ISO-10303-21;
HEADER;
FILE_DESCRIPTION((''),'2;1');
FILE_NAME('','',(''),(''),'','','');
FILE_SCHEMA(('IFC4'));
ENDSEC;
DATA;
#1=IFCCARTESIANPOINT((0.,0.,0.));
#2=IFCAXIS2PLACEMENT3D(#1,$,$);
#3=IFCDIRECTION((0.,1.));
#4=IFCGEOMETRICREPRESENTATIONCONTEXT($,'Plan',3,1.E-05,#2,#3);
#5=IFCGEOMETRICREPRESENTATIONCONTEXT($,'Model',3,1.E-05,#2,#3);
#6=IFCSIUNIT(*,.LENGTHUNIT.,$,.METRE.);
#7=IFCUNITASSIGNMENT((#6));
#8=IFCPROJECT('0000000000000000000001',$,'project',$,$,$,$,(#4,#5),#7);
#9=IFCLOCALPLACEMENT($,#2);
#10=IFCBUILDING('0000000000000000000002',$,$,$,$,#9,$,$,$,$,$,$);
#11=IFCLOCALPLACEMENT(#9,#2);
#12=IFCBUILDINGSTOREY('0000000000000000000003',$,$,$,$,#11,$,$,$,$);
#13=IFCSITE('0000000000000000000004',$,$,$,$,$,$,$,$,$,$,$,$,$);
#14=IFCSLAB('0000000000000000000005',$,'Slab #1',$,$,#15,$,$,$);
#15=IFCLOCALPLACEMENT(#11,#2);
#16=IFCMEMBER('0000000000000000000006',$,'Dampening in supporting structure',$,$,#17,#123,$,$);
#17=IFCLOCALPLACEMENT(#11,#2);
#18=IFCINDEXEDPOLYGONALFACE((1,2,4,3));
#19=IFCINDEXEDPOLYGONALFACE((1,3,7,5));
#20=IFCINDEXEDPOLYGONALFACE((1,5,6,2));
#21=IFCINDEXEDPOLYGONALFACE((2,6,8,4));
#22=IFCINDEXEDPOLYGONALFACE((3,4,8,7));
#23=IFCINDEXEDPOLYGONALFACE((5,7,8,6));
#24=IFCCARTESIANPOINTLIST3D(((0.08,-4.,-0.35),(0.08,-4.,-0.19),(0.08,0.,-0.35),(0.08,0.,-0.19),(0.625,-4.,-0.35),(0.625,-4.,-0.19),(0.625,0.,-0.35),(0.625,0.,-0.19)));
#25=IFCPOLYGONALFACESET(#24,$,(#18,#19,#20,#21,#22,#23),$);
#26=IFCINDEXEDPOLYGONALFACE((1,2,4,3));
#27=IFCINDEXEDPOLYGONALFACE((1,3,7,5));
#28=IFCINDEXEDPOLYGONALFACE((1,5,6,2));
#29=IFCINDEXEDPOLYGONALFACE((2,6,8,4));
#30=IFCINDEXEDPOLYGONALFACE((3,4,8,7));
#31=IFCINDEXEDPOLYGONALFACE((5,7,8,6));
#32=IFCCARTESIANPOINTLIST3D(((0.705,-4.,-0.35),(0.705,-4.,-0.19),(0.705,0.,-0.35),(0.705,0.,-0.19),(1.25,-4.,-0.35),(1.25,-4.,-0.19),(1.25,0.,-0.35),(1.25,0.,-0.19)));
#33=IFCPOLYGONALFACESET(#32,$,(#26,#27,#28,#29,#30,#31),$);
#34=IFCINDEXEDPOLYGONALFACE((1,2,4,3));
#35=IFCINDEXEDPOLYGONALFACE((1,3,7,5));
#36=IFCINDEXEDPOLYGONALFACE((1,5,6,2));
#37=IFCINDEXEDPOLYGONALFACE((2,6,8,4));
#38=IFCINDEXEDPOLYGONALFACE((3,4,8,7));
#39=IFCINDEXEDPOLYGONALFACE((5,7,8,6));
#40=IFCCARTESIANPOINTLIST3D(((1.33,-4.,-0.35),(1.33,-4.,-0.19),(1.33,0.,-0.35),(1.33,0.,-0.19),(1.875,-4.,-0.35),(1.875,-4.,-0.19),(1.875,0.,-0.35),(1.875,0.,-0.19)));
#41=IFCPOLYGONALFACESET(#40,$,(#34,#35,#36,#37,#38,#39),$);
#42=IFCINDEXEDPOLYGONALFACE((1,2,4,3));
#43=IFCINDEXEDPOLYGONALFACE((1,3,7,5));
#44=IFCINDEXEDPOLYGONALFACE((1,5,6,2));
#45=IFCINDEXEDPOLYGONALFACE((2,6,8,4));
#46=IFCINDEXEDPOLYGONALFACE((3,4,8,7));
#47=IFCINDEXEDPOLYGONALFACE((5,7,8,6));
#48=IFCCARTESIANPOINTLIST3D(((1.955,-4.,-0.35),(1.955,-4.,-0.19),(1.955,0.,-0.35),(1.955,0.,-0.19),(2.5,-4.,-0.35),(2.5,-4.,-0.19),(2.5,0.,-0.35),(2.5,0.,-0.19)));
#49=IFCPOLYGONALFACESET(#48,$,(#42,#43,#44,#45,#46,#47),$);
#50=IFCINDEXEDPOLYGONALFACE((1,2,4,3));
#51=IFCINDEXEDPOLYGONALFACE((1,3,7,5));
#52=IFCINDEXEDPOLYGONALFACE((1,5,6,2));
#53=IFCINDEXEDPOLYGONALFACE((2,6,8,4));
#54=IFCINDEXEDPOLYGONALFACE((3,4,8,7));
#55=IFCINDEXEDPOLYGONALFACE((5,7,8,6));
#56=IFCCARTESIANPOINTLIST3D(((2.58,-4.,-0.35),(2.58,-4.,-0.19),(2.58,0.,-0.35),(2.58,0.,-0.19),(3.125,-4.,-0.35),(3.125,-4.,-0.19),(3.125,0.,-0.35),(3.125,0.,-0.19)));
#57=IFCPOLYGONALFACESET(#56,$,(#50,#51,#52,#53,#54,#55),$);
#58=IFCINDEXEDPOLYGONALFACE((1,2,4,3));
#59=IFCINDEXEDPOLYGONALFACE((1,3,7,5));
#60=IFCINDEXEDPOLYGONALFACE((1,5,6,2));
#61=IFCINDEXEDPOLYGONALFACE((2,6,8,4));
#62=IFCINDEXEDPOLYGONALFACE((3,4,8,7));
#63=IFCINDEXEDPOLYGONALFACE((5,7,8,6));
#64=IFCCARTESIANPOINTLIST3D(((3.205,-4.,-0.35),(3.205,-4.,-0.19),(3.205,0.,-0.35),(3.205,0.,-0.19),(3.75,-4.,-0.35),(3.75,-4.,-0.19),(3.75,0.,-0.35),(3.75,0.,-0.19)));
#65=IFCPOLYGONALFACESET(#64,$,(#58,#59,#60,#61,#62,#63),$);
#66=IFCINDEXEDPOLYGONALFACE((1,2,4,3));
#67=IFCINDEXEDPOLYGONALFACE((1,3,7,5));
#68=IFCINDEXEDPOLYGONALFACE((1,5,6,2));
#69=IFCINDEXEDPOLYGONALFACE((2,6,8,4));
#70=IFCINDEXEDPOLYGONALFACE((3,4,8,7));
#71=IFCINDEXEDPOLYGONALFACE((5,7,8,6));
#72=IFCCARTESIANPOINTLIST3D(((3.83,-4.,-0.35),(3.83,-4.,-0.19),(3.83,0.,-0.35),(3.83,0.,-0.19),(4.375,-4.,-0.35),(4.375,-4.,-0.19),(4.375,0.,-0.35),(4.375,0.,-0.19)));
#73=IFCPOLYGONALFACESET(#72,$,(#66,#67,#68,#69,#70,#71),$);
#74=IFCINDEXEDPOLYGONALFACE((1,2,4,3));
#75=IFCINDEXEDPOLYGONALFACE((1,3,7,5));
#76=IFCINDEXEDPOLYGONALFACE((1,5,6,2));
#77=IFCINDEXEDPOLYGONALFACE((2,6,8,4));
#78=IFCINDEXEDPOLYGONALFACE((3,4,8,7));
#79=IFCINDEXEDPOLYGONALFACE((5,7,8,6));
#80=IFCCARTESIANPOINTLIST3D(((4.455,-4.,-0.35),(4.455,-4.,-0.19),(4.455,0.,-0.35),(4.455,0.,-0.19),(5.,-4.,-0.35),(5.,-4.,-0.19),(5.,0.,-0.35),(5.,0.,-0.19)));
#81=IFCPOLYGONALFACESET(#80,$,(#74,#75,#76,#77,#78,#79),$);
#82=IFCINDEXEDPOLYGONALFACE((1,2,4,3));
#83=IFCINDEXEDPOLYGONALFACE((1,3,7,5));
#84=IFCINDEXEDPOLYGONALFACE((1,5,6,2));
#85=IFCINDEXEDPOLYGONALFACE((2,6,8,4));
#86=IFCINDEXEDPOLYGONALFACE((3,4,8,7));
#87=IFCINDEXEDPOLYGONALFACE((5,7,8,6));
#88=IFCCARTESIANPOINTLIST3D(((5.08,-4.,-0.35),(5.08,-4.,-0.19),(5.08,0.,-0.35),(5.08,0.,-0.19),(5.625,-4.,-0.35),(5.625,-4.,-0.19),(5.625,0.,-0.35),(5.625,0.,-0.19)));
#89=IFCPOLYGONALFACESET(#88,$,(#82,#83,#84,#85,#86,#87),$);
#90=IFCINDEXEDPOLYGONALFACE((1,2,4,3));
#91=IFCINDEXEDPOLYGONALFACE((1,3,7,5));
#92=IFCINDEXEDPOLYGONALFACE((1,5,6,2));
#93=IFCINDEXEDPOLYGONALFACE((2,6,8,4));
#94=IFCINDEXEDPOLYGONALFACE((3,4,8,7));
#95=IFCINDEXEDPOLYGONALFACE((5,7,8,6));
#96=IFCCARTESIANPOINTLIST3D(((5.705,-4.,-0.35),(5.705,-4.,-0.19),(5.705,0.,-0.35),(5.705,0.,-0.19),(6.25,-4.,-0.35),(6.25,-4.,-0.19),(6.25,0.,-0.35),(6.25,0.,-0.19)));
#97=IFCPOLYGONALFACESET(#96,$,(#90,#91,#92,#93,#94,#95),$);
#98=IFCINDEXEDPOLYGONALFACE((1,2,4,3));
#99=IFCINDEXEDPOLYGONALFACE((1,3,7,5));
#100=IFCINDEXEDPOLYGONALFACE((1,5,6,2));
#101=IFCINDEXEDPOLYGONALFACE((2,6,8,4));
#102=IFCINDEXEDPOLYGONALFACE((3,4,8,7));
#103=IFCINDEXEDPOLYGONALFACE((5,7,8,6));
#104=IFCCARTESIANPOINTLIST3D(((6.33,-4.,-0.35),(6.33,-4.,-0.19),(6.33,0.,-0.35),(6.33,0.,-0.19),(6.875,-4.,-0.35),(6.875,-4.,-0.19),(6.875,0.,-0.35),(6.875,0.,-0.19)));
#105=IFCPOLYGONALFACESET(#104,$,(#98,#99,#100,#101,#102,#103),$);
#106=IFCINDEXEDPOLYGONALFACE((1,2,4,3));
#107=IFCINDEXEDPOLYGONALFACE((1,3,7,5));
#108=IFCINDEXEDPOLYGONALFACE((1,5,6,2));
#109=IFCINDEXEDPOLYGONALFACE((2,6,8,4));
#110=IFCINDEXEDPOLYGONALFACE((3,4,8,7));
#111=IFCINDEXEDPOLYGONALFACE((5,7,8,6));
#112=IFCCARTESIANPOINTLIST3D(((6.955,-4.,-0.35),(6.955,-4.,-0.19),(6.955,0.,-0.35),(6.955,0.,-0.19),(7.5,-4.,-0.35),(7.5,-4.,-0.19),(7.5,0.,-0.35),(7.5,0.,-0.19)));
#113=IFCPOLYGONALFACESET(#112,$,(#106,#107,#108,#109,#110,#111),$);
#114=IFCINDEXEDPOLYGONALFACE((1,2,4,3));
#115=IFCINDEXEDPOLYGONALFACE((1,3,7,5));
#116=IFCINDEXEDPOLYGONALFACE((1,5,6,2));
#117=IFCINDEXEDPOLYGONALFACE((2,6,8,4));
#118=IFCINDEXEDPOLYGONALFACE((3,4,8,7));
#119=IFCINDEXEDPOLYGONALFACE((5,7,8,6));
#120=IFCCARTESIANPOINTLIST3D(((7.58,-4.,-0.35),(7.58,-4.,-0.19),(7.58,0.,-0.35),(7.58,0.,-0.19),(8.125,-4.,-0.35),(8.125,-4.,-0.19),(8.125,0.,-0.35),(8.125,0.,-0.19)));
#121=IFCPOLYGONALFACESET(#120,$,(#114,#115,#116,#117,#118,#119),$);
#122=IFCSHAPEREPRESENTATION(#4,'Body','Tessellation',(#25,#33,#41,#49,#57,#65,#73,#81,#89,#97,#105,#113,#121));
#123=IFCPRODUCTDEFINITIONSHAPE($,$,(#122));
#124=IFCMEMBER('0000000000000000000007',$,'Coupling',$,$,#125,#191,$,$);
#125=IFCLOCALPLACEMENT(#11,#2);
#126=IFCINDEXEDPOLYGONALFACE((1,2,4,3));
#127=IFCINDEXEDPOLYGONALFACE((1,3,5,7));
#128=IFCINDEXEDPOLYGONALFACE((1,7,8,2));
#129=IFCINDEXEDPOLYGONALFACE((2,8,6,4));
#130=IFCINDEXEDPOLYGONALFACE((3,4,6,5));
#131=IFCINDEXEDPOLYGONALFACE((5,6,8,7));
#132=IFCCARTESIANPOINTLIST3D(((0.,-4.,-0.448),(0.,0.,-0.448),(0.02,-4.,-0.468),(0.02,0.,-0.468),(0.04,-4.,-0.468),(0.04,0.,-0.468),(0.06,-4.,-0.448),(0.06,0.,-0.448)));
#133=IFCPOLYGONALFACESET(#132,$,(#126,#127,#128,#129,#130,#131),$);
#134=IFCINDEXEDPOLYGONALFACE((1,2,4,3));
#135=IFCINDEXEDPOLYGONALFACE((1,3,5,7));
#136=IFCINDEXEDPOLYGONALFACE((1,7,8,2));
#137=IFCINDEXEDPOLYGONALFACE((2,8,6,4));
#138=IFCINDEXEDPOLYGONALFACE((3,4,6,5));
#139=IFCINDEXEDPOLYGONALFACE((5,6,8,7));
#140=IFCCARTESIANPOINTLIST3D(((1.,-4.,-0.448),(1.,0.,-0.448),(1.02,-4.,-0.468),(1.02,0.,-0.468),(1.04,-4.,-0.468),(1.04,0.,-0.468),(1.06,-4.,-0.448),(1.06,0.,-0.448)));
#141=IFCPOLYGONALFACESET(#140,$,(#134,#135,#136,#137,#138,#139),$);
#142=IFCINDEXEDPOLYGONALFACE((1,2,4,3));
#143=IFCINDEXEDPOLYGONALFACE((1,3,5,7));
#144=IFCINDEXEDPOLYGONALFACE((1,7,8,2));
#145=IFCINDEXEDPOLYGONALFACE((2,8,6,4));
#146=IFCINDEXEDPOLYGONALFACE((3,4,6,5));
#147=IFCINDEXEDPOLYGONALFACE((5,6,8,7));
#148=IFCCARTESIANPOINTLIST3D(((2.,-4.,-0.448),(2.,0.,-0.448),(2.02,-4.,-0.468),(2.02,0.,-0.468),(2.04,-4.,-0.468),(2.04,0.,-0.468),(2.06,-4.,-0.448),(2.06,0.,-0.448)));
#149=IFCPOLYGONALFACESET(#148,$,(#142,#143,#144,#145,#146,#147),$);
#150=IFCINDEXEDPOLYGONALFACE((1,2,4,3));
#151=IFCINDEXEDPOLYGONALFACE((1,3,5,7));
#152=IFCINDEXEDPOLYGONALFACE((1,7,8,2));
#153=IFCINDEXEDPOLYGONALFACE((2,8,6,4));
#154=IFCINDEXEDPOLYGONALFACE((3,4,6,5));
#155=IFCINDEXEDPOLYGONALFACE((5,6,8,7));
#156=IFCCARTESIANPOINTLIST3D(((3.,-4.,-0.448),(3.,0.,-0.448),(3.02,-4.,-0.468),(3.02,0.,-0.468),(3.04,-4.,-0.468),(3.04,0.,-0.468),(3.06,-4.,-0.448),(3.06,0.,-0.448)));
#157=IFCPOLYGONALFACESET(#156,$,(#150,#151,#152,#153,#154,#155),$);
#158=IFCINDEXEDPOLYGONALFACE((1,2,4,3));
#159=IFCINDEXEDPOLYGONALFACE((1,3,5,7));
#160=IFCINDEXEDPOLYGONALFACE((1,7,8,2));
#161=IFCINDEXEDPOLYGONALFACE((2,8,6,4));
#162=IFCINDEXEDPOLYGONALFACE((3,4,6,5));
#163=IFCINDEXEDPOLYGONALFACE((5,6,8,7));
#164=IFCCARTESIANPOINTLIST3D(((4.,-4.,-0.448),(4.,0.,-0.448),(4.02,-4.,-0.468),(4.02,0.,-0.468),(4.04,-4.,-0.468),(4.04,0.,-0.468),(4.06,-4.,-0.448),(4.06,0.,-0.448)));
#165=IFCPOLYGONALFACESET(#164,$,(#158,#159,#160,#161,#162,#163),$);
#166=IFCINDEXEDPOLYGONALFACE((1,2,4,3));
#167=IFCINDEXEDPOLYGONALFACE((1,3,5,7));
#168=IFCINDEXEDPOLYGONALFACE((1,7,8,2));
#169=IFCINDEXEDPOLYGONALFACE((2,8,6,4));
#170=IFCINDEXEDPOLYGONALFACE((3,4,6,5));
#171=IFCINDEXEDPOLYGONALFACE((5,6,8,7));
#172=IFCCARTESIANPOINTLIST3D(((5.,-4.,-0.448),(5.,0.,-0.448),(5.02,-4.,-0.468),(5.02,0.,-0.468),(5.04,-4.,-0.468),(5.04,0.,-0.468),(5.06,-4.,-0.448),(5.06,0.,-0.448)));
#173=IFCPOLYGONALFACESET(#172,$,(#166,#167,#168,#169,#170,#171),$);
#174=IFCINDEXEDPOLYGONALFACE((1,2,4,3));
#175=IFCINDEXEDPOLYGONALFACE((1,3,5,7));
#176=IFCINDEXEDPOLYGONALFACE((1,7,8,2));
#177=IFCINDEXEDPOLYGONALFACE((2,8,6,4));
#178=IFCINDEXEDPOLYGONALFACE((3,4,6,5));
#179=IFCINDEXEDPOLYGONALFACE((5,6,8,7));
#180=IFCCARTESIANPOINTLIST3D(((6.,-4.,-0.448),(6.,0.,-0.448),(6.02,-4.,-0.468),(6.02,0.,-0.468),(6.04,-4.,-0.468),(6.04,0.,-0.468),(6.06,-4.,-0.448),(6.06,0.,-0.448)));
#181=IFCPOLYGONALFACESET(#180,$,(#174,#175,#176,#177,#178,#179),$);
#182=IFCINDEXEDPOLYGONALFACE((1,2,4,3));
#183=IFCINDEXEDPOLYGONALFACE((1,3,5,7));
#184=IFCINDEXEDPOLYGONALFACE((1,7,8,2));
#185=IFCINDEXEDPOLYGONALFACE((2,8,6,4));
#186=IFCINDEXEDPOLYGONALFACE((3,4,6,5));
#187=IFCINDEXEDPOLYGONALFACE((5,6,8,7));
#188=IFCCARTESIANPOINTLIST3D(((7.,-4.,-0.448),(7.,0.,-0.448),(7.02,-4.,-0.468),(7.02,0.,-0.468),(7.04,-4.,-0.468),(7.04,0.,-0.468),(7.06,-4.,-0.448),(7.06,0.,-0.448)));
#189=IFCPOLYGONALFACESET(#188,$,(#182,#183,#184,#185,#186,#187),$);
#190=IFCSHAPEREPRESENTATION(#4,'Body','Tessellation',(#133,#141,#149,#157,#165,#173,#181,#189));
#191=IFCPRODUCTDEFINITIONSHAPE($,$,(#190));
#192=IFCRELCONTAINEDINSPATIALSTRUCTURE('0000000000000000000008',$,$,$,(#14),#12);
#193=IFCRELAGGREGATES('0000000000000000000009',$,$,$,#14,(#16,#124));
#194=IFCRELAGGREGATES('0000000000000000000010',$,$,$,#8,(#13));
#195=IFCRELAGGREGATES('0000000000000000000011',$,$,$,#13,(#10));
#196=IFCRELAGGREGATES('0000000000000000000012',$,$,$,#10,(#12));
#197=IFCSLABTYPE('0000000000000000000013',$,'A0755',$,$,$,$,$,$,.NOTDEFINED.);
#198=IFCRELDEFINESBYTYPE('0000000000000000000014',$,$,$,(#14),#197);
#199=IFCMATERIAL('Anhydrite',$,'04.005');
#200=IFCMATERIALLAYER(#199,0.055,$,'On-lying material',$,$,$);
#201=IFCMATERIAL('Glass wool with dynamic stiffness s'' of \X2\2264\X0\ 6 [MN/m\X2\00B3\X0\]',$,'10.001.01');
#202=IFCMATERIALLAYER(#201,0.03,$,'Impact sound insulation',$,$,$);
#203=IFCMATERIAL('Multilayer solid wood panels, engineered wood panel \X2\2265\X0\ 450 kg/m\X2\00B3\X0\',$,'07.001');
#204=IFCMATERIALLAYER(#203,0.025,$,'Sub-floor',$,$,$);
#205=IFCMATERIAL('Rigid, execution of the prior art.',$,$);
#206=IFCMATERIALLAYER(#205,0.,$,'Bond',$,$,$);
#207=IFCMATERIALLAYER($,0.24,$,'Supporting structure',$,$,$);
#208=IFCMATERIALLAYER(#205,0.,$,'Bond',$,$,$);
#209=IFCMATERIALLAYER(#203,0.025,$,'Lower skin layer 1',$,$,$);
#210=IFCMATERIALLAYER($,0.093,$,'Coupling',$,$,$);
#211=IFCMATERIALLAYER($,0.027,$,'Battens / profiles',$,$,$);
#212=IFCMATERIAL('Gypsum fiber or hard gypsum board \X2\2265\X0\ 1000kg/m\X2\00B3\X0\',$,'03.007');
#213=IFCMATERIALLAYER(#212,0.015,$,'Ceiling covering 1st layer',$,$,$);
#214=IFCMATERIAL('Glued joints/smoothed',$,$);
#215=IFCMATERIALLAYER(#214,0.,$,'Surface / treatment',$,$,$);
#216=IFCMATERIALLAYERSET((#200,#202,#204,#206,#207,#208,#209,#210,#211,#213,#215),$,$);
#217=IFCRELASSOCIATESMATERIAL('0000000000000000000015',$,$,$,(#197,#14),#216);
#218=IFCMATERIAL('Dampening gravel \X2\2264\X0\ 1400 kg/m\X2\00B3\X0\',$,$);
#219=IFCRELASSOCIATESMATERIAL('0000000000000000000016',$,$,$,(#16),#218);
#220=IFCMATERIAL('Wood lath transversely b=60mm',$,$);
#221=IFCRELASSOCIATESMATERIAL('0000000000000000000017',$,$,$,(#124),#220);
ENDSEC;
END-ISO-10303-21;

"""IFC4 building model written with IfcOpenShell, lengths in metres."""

from ifc_helpers import new_model, si_unit, direction, frame, frame_2d, origin, place, context, project, spatial, polyline, rectangle, outline, extrude, material, layer, layer_set, type_object, element, aggregate, save


model = new_model("IFC4")

# Units and contexts
plan_context = context("Plan", 3, precision=1e-05, world=origin(), true_north=direction((0.0, 1.0)))
model_context = context("Model", 3, precision=1e-05, world=origin(), true_north=direction((0.0, 1.0)))
ifc_project = project(units=[si_unit("LENGTHUNIT", "METRE")], contexts=[plan_context, model_context])

# Site, building, storey
site = spatial("IfcSite", under=ifc_project)
building_placement = place(None, origin())
building = spatial("IfcBuilding", under=site, at=building_placement)
storey_placement = place(building_placement, origin())
storey = spatial("IfcBuildingStorey", under=building, at=storey_placement)

# Slab, members
ifc_material_1 = material(Name="Anhydrite", Category="04.005")
ifc_layer_1 = layer(ifc_material_1, 0.055, Name="On-lying material")
ifc_material_2 = material(Name="Glass wool with dynamic stiffness s' of ≤ 6 [MN/m³]", Category="10.001.01")
ifc_layer_2 = layer(ifc_material_2, 0.03, Name="Impact sound insulation")
ifc_material_3 = material(Name="Multilayer solid wood panels, engineered wood panel ≥ 450 kg/m³", Category="07.001")
ifc_layer_3 = layer(ifc_material_3, 0.025, Name="Sub-floor")
ifc_material_4 = material(Name="Rigid, execution of the prior art.")
ifc_layer_4 = layer(ifc_material_4, 0.0, Name="Bond")
ifc_layer_5 = layer(None, 0.24, Name="Supporting structure")
ifc_layer_6 = layer(ifc_material_4, 0.0, Name="Bond")
ifc_layer_7 = layer(ifc_material_3, 0.025, Name="Lower skin layer 1")
ifc_layer_8 = layer(None, 0.093, Name="Coupling")
ifc_layer_9 = layer(None, 0.027, Name="Battens / profiles")
ifc_material_5 = material(Name="Gypsum fiber or hard gypsum board ≥ 1000kg/m³", Category="03.007")
ifc_layer_10 = layer(ifc_material_5, 0.015, Name="Ceiling covering 1st layer")
ifc_material_6 = material(Name="Glued joints/smoothed")
ifc_layer_11 = layer(ifc_material_6, 0.0, Name="Surface / treatment")
ifc_layer_set = layer_set([ifc_layer_1, ifc_layer_2, ifc_layer_3, ifc_layer_4, ifc_layer_5, ifc_layer_6, ifc_layer_7, ifc_layer_8, ifc_layer_9, ifc_layer_10, ifc_layer_11])
slab_type = type_object("IfcSlabType", Name="A0755", PredefinedType="NOTDEFINED", material=ifc_layer_set)
slab_placement = place(None, frame((0.0, 0.0, 0.0), z_axis=(0.0, 0.0, -1.0), x_axis=(1.0, 0.0, 0.0)))
slab = element("IfcSlab", 1, at=slab_placement, inside=storey, type_object=slab_type, material=ifc_layer_set, Name="Slab #1")
ifc_material_7 = material(Name="Dampening gravel ≤ 1400 kg/m³")
member_1_placement = place(slab_placement, origin())
member_1 = element("IfcMember", 2, at=member_1_placement, material=ifc_material_7, Name="Dampening in supporting structure", context=plan_context, shape_type="SweptSolid", body=[
    extrude(rectangle(XDim=0.545, YDim=0.16, at=frame_2d((0.2725, 0.08), x_axis=(1.0, 0.0))), frame((0.08, 4.0, 0.19), z_axis=(0.0, -1.0, 0.0), x_axis=(1.0, 0.0, 0.0)), (0.0, 0.0, 1.0), 4.0),
    extrude(rectangle(XDim=0.545, YDim=0.16, at=frame_2d((0.2725, 0.08), x_axis=(1.0, 0.0))), frame((0.705, 4.0, 0.19), z_axis=(0.0, -1.0, 0.0), x_axis=(1.0, 0.0, 0.0)), (0.0, 0.0, 1.0), 4.0),
    extrude(rectangle(XDim=0.545, YDim=0.16, at=frame_2d((0.2725, 0.08), x_axis=(1.0, 0.0))), frame((1.33, 4.0, 0.19), z_axis=(0.0, -1.0, 0.0), x_axis=(1.0, 0.0, 0.0)), (0.0, 0.0, 1.0), 4.0),
    extrude(rectangle(XDim=0.545, YDim=0.16, at=frame_2d((0.2725, 0.08), x_axis=(1.0, 0.0))), frame((1.955, 4.0, 0.19), z_axis=(0.0, -1.0, 0.0), x_axis=(1.0, 0.0, 0.0)), (0.0, 0.0, 1.0), 4.0),
    extrude(rectangle(XDim=0.545, YDim=0.16, at=frame_2d((0.2725, 0.08), x_axis=(1.0, 0.0))), frame((2.58, 4.0, 0.19), z_axis=(0.0, -1.0, 0.0), x_axis=(1.0, 0.0, 0.0)), (0.0, 0.0, 1.0), 4.0),
    extrude(rectangle(XDim=0.545, YDim=0.16, at=frame_2d((0.2725, 0.08), x_axis=(1.0, 0.0))), frame((3.205, 4.0, 0.19), z_axis=(0.0, -1.0, 0.0), x_axis=(1.0, 0.0, 0.0)), (0.0, 0.0, 1.0), 4.0),
    extrude(rectangle(XDim=0.545, YDim=0.16, at=frame_2d((0.2725, 0.08), x_axis=(1.0, 0.0))), frame((3.83, 4.0, 0.19), z_axis=(0.0, -1.0, 0.0), x_axis=(1.0, 0.0, 0.0)), (0.0, 0.0, 1.0), 4.0),
    extrude(rectangle(XDim=0.545, YDim=0.16, at=frame_2d((0.2725, 0.08), x_axis=(1.0, 0.0))), frame((4.455, 4.0, 0.19), z_axis=(0.0, -1.0, 0.0), x_axis=(1.0, 0.0, 0.0)), (0.0, 0.0, 1.0), 4.0),
    extrude(rectangle(XDim=0.545, YDim=0.16, at=frame_2d((0.2725, 0.08), x_axis=(1.0, 0.0))), frame((5.08, 4.0, 0.19), z_axis=(0.0, -1.0, 0.0), x_axis=(1.0, 0.0, 0.0)), (0.0, 0.0, 1.0), 4.0),
    extrude(rectangle(XDim=0.545, YDim=0.16, at=frame_2d((0.2725, 0.08), x_axis=(1.0, 0.0))), frame((5.705, 4.0, 0.19), z_axis=(0.0, -1.0, 0.0), x_axis=(1.0, 0.0, 0.0)), (0.0, 0.0, 1.0), 4.0),
    extrude(rectangle(XDim=0.545, YDim=0.16, at=frame_2d((0.2725, 0.08), x_axis=(1.0, 0.0))), frame((6.33, 4.0, 0.19), z_axis=(0.0, -1.0, 0.0), x_axis=(1.0, 0.0, 0.0)), (0.0, 0.0, 1.0), 4.0),
    extrude(rectangle(XDim=0.545, YDim=0.16, at=frame_2d((0.2725, 0.08), x_axis=(1.0, 0.0))), frame((6.955, 4.0, 0.19), z_axis=(0.0, -1.0, 0.0), x_axis=(1.0, 0.0, 0.0)), (0.0, 0.0, 1.0), 4.0),
    extrude(rectangle(XDim=0.545, YDim=0.16, at=frame_2d((0.2725, 0.08), x_axis=(1.0, 0.0))), frame((7.58, 4.0, 0.19), z_axis=(0.0, -1.0, 0.0), x_axis=(1.0, 0.0, 0.0)), (0.0, 0.0, 1.0), 4.0),
])
ifc_material_8 = material(Name="Wood lath transversely b=60mm")
member_2_placement = place(slab_placement, origin())
member_2 = element("IfcMember", 3, at=member_2_placement, material=ifc_material_8, Name="Coupling", context=plan_context, shape_type="SweptSolid", body=[
    extrude(outline(polyline([(0.0, 0.0), (0.06, 0.0), (0.04, 0.02), (0.02, 0.02), (0.0, 0.0)])), frame((0.0, 4.0, 0.448), z_axis=(0.0, -1.0, 0.0), x_axis=(1.0, 0.0, 0.0)), (0.0, 0.0, 1.0), 4.0),
    extrude(outline(polyline([(0.0, 0.0), (0.06, 0.0), (0.04, 0.02), (0.02, 0.02), (0.0, 0.0)])), frame((1.0, 4.0, 0.448), z_axis=(0.0, -1.0, 0.0), x_axis=(1.0, 0.0, 0.0)), (0.0, 0.0, 1.0), 4.0),
    extrude(outline(polyline([(0.0, 0.0), (0.06, 0.0), (0.04, 0.02), (0.02, 0.02), (0.0, 0.0)])), frame((2.0, 4.0, 0.448), z_axis=(0.0, -1.0, 0.0), x_axis=(1.0, 0.0, 0.0)), (0.0, 0.0, 1.0), 4.0),
    extrude(outline(polyline([(0.0, 0.0), (0.06, 0.0), (0.04, 0.02), (0.02, 0.02), (0.0, 0.0)])), frame((3.0, 4.0, 0.448), z_axis=(0.0, -1.0, 0.0), x_axis=(1.0, 0.0, 0.0)), (0.0, 0.0, 1.0), 4.0),
    extrude(outline(polyline([(0.0, 0.0), (0.06, 0.0), (0.04, 0.02), (0.02, 0.02), (0.0, 0.0)])), frame((4.0, 4.0, 0.448), z_axis=(0.0, -1.0, 0.0), x_axis=(1.0, 0.0, 0.0)), (0.0, 0.0, 1.0), 4.0),
    extrude(outline(polyline([(0.0, 0.0), (0.06, 0.0), (0.04, 0.02), (0.02, 0.02), (0.0, 0.0)])), frame((5.0, 4.0, 0.448), z_axis=(0.0, -1.0, 0.0), x_axis=(1.0, 0.0, 0.0)), (0.0, 0.0, 1.0), 4.0),
    extrude(outline(polyline([(0.0, 0.0), (0.06, 0.0), (0.04, 0.02), (0.02, 0.02), (0.0, 0.0)])), frame((6.0, 4.0, 0.448), z_axis=(0.0, -1.0, 0.0), x_axis=(1.0, 0.0, 0.0)), (0.0, 0.0, 1.0), 4.0),
    extrude(outline(polyline([(0.0, 0.0), (0.06, 0.0), (0.04, 0.02), (0.02, 0.02), (0.0, 0.0)])), frame((7.0, 4.0, 0.448), z_axis=(0.0, -1.0, 0.0), x_axis=(1.0, 0.0, 0.0)), (0.0, 0.0, 1.0), 4.0),
])
aggregate(slab, [member_1, member_2])

save(model, "model.ifc")
